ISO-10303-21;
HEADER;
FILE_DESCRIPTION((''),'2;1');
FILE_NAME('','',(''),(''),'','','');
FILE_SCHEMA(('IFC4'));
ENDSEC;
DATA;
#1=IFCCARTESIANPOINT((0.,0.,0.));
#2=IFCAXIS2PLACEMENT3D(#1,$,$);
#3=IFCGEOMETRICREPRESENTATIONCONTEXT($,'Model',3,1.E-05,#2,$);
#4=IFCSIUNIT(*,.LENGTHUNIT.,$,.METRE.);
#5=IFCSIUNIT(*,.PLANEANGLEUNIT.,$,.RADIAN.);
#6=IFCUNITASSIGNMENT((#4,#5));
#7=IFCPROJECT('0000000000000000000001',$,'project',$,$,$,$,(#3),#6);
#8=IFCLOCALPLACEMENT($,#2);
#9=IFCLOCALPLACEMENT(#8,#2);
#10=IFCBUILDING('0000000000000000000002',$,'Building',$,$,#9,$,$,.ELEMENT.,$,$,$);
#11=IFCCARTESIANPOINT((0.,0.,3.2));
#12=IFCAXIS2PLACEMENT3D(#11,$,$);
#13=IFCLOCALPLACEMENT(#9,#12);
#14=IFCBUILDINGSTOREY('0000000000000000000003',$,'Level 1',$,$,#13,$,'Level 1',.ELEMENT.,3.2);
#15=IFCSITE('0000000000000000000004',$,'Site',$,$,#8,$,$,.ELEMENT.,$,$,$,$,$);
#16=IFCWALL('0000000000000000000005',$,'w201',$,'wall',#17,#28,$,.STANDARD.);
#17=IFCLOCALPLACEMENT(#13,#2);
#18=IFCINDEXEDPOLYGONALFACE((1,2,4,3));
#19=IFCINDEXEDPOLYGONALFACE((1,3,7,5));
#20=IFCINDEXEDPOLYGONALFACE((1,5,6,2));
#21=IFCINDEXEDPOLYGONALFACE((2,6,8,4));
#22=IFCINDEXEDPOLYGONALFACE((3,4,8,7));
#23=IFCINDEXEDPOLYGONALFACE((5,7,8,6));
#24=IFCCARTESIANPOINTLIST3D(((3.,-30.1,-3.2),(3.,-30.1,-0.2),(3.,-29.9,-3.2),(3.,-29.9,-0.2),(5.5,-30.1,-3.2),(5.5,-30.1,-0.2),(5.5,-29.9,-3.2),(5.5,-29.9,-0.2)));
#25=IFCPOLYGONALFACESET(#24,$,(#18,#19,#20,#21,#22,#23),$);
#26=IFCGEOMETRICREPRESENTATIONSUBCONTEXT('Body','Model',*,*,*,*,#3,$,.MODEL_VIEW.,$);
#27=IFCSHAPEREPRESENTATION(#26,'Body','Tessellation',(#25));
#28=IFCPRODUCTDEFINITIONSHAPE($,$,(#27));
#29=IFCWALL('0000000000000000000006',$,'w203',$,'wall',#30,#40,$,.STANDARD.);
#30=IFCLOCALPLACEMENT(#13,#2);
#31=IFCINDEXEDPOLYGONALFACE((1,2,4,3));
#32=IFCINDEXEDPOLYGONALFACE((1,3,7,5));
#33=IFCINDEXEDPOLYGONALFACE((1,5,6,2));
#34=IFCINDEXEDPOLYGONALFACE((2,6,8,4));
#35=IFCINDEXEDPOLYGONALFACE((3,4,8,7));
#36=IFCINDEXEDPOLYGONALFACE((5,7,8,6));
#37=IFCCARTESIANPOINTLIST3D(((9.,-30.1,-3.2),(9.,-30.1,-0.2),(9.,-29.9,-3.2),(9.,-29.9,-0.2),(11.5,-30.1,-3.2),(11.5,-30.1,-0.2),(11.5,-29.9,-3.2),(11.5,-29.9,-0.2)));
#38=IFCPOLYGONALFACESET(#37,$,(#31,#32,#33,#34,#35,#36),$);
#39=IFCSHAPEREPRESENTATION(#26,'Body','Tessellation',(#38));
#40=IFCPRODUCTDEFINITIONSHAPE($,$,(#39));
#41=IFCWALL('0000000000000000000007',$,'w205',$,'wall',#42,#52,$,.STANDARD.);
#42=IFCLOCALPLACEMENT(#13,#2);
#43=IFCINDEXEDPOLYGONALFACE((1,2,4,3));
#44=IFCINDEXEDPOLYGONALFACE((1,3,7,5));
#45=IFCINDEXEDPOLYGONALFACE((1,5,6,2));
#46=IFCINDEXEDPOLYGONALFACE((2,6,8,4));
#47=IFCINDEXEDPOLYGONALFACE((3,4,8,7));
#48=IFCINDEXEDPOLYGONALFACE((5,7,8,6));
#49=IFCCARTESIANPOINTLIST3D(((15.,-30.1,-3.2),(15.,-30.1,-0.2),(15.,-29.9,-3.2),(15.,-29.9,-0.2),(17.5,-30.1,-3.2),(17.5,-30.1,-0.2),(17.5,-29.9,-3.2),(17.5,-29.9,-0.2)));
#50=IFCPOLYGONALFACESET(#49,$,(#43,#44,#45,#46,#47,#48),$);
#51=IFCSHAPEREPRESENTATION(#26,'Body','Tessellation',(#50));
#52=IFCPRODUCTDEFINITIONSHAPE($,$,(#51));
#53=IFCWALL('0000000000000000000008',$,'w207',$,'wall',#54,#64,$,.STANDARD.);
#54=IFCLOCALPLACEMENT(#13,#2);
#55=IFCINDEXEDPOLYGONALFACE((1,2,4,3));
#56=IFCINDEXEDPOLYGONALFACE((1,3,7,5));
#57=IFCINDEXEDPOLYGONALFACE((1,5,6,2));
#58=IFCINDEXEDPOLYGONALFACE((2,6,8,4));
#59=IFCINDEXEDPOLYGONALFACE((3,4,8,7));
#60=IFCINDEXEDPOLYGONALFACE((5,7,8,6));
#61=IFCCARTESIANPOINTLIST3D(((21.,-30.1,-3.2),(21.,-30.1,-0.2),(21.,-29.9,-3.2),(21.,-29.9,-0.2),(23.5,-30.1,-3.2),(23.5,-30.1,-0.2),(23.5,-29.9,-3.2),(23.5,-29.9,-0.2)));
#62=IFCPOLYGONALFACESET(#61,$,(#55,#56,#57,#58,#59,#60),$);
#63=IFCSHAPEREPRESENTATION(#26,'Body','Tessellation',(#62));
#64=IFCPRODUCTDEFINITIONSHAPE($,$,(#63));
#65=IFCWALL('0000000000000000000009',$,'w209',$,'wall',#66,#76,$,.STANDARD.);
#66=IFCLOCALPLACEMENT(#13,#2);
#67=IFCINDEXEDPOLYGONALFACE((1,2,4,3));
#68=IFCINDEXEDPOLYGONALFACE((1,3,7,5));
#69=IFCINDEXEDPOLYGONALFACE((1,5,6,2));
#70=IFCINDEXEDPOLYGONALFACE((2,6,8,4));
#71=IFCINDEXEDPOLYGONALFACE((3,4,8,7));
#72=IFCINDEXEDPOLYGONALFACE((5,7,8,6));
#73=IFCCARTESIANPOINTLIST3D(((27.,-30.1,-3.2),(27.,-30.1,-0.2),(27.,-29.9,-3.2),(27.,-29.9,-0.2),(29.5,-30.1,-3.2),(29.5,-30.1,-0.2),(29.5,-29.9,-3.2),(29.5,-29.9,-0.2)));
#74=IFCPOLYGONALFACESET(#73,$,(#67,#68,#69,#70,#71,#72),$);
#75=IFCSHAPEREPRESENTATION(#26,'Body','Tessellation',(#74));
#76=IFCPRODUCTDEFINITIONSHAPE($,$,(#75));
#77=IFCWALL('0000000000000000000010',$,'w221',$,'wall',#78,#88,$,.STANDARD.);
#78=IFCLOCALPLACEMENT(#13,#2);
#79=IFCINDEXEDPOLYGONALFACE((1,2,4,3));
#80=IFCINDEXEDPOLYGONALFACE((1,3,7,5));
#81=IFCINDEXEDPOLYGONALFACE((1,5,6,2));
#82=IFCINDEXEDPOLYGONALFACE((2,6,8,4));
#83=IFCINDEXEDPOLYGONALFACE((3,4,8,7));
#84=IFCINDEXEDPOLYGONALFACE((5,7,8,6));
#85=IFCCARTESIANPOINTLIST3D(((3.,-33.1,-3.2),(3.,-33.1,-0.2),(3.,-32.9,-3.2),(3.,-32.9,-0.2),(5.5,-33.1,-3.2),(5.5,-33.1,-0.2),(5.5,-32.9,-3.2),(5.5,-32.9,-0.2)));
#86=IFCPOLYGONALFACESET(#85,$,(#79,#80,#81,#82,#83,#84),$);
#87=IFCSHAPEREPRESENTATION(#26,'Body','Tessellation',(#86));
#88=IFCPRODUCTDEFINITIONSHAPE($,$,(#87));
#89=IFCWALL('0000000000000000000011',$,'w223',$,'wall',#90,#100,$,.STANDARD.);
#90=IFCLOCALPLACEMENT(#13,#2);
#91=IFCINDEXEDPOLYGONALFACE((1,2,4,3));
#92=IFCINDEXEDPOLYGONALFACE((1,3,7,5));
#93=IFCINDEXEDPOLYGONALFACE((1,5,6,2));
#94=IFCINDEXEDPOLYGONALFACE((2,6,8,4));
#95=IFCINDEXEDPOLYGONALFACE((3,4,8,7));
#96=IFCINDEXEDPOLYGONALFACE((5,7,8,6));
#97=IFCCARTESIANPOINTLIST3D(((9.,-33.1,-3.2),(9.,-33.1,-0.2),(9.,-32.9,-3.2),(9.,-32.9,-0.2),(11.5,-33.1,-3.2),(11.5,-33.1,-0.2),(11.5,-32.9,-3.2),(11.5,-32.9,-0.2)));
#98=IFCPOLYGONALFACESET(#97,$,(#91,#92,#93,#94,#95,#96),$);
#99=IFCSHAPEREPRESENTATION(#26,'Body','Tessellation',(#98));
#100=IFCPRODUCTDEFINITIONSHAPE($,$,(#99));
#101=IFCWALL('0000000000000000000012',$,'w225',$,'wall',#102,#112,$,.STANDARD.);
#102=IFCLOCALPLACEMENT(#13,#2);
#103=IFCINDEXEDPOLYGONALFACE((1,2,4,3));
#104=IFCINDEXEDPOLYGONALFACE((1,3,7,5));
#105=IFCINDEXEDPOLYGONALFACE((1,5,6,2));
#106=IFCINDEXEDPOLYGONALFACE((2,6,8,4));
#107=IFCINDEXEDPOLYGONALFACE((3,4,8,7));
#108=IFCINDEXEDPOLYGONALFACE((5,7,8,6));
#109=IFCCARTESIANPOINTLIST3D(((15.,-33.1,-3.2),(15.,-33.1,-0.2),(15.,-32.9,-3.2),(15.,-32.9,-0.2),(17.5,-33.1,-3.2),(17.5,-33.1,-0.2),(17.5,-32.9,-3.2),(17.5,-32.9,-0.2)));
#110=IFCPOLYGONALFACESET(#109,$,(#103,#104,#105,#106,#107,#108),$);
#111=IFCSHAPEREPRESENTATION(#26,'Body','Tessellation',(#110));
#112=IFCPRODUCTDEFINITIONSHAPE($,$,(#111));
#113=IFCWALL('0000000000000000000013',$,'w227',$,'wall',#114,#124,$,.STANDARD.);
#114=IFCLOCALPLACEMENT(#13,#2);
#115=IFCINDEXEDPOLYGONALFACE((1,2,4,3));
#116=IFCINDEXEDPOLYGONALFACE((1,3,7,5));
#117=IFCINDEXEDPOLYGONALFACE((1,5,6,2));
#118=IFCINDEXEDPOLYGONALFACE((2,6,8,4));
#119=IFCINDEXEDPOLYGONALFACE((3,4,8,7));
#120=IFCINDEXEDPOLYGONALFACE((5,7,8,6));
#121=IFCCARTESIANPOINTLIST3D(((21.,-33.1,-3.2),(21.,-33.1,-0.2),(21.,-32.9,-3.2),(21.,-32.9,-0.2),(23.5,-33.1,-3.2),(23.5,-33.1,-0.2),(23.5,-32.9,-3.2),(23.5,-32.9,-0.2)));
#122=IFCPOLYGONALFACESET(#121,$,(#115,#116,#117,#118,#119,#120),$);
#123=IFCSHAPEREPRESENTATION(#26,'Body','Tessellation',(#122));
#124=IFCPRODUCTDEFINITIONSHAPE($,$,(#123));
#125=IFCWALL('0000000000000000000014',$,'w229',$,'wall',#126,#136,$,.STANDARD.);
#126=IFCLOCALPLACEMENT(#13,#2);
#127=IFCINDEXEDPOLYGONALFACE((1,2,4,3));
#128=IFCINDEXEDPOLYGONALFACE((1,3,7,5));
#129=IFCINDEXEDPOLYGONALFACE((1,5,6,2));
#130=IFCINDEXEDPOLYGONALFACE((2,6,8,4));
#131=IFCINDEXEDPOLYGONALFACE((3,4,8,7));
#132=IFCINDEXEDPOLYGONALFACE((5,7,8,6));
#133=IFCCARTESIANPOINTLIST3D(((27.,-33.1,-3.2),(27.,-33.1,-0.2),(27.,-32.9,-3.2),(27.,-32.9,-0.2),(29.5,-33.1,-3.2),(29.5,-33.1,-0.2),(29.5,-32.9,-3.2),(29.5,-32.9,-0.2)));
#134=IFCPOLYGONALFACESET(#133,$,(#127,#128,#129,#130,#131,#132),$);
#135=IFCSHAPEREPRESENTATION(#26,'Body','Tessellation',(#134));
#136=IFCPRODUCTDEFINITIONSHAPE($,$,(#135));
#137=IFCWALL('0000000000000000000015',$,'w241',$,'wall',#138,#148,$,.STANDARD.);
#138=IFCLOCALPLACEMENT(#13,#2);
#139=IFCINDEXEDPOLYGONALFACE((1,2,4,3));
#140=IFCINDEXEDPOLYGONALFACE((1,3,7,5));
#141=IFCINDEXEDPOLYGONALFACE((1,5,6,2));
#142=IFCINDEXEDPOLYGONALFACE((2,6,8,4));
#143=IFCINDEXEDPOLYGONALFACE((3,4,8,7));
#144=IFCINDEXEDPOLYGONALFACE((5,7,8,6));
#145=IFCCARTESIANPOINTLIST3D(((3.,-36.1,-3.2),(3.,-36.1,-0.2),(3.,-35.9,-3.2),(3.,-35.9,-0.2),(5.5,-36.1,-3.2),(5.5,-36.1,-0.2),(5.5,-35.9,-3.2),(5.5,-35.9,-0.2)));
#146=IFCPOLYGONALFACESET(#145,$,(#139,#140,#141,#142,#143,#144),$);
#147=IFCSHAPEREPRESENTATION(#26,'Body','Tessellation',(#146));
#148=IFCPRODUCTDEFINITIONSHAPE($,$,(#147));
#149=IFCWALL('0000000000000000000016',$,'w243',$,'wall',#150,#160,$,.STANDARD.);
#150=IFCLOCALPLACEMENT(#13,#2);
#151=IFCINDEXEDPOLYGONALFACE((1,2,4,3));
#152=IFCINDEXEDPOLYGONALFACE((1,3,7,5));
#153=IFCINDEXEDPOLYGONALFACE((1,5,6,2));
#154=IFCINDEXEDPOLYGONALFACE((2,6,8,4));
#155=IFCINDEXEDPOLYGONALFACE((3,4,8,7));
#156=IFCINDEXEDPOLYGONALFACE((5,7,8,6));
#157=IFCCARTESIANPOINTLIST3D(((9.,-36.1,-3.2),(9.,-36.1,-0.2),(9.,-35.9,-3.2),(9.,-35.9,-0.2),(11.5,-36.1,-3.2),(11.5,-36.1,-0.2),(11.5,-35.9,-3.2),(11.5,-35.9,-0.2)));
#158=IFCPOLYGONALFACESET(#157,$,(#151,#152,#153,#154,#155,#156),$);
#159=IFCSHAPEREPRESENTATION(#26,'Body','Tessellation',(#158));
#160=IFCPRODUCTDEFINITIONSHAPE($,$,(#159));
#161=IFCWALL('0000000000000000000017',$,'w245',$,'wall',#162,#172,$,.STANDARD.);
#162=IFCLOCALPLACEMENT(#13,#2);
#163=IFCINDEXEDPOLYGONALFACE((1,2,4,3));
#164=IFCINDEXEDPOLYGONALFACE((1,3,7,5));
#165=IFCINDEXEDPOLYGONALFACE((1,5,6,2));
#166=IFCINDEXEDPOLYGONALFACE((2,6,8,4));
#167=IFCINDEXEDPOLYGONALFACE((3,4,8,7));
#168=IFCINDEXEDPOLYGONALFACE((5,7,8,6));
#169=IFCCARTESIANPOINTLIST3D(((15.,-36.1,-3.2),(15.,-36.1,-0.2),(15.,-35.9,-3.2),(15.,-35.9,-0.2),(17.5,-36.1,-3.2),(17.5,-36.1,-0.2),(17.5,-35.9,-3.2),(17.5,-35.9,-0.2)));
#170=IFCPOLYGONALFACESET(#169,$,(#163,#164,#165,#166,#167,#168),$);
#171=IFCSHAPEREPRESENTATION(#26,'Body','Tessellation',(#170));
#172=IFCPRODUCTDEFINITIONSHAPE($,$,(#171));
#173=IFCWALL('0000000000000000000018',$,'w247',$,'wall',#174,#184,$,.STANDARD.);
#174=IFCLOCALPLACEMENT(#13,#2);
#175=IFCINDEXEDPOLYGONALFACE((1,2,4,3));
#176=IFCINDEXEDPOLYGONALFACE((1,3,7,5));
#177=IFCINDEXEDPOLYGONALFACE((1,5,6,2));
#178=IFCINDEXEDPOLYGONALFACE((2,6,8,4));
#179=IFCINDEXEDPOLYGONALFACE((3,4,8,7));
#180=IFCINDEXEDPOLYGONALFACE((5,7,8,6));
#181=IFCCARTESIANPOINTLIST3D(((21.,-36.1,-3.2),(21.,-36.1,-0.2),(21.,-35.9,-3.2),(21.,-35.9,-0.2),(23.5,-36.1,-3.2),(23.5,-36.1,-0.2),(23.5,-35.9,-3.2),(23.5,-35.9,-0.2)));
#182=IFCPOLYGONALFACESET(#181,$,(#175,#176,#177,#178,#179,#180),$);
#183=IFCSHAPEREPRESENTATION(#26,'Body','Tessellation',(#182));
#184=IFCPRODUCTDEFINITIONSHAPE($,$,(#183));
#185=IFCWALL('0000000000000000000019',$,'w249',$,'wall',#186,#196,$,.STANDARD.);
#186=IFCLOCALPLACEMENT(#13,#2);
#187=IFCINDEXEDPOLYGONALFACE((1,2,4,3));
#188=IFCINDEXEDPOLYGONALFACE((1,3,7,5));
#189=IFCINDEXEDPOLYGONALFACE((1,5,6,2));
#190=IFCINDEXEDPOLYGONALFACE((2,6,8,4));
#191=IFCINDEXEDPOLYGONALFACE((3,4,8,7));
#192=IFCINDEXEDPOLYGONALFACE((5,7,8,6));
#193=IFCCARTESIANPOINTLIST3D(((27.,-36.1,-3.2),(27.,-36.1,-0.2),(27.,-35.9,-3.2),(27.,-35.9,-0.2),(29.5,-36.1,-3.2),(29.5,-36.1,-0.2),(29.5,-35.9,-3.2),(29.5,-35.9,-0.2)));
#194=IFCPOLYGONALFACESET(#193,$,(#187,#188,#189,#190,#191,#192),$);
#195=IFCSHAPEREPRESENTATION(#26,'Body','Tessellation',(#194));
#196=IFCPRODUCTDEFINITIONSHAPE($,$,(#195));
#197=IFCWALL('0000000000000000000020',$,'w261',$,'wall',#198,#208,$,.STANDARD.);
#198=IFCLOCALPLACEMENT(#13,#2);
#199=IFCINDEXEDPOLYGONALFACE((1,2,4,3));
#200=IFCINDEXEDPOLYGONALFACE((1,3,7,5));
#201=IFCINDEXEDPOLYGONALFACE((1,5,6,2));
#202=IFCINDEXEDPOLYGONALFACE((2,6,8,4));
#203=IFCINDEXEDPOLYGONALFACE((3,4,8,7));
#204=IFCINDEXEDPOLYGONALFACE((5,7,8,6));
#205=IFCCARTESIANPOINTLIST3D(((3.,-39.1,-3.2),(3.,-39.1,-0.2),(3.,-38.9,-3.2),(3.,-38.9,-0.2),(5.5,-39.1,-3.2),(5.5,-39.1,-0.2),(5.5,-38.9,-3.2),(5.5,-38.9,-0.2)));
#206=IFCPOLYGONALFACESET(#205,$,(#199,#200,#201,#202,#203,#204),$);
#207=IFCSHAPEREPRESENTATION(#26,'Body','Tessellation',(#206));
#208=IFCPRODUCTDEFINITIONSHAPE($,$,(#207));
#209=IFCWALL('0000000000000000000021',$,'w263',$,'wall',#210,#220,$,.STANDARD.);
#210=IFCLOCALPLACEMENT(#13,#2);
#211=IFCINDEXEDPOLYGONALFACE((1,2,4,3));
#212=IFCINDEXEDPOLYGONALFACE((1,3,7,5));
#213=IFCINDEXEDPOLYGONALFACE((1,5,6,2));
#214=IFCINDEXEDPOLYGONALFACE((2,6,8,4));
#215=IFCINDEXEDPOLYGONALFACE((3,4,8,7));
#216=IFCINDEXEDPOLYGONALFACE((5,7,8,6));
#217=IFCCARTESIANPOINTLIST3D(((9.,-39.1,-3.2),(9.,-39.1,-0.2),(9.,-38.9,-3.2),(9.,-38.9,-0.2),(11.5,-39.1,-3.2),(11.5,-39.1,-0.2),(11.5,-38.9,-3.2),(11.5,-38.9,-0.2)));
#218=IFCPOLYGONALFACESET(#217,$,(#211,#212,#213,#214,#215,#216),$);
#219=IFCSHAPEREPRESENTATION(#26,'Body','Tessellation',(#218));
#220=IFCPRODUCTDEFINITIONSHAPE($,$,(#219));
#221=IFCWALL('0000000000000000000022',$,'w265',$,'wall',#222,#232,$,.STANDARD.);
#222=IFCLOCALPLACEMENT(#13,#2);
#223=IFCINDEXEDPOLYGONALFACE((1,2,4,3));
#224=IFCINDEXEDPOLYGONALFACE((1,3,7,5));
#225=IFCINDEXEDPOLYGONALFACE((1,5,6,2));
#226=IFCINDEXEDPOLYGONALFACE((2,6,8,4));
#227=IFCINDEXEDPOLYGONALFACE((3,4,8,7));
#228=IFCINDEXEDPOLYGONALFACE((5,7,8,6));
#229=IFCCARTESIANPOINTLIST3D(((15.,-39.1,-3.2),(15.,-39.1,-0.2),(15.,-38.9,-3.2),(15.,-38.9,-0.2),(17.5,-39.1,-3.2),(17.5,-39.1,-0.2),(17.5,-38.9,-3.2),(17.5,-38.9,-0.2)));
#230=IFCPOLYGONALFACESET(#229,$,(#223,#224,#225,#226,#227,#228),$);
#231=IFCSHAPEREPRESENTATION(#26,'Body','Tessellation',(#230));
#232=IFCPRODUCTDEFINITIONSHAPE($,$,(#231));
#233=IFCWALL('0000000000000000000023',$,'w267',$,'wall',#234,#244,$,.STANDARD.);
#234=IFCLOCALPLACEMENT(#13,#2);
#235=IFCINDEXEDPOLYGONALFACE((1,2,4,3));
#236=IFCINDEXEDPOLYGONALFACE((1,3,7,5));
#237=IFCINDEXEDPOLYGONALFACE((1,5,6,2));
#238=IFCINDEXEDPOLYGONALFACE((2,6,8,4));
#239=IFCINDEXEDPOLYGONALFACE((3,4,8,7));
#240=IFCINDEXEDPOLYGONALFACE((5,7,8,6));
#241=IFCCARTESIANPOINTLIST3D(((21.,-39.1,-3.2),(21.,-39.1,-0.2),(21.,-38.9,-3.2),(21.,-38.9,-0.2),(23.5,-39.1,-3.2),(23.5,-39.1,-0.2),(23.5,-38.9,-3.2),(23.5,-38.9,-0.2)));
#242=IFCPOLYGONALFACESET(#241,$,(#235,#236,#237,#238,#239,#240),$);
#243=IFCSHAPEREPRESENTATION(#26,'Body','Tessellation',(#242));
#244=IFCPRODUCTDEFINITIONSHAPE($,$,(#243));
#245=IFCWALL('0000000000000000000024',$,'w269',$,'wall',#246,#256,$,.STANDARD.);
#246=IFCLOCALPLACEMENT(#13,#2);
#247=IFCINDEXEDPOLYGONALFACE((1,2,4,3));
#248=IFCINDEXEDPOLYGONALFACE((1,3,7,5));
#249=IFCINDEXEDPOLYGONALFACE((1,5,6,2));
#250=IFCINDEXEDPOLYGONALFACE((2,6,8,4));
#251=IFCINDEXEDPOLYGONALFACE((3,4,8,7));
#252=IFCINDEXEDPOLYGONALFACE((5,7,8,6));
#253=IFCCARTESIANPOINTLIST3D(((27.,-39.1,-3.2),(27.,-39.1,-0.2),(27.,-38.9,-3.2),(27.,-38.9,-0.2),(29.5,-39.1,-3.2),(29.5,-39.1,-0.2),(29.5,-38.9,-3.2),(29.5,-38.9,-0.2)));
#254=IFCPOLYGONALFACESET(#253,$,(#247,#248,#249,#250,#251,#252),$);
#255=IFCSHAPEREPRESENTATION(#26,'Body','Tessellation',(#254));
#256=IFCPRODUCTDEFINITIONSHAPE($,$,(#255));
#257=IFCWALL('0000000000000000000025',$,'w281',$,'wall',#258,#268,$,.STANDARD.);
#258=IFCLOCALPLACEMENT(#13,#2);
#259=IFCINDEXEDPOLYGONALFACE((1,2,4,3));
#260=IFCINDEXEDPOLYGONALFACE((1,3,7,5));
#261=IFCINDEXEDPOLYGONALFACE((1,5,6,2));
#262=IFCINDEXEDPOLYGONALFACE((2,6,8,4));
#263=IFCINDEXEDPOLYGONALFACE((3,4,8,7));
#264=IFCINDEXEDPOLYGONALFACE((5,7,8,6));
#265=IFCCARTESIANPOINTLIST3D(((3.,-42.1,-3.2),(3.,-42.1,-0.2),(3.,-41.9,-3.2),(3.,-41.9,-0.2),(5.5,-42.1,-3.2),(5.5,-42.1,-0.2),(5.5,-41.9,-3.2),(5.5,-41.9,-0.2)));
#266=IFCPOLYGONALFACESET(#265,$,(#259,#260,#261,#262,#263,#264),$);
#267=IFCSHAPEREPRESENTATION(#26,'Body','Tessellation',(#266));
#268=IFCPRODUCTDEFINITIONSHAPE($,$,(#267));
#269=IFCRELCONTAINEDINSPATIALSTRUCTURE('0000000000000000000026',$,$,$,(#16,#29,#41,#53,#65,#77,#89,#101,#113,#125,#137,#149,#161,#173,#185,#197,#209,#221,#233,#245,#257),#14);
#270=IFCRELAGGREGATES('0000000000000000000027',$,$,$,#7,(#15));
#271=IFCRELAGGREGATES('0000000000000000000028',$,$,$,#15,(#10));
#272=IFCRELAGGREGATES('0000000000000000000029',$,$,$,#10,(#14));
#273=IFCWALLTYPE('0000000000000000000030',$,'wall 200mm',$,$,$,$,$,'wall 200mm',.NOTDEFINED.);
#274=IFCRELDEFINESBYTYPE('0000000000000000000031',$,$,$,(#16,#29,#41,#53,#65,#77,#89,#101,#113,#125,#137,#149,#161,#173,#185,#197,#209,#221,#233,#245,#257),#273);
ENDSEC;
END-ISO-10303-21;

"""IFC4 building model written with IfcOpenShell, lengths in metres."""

from ifc_helpers import new_model, si_unit, frame, frame_2d, origin, place, context, subcontext, project, spatial, rectangle, extrude, type_object, element, save


model = new_model("IFC4")

# Units and contexts
model_context = context("Model", 3, precision=1e-05, world=origin())
body_context = subcontext(model_context, "Body", "Model", "MODEL_VIEW")
ifc_project = project(units=[si_unit("LENGTHUNIT", "METRE"), si_unit("PLANEANGLEUNIT", "RADIAN")], contexts=[model_context])

# Site, building, storey
site_placement = place(None, origin())
site = spatial("IfcSite", under=ifc_project, at=site_placement, Name="Site", CompositionType="ELEMENT")
building_placement = place(site_placement, origin())
building = spatial("IfcBuilding", under=site, at=building_placement, Name="Building", CompositionType="ELEMENT")
storey_placement = place(building_placement, frame((0.0, 0.0, 3.2)))
storey = spatial("IfcBuildingStorey", under=building, at=storey_placement, Name="Level 1", LongName="Level 1", CompositionType="ELEMENT", Elevation=3.2)

# Walls
wall_type = type_object("IfcWallType", Name="wall 200mm", ElementType="wall 200mm", PredefinedType="NOTDEFINED")
for number, where, z_axis, x_axis, name in (
    (1, (3.0, -30.0, -3.2), (0.0, 0.0, 1.0), (1.0, 0.0, 0.0), "w201"),
    (2, (9.0, -30.0, -3.2), (0.0, 0.0, 1.0), (1.0, 0.0, 0.0), "w203"),
    (3, (15.0, -30.0, -3.2), (0.0, 0.0, 1.0), (1.0, 0.0, 0.0), "w205"),
    (4, (21.0, -30.0, -3.2), (0.0, 0.0, 1.0), (1.0, 0.0, 0.0), "w207"),
    (5, (27.0, -30.0, -3.2), (0.0, 0.0, 1.0), (1.0, 0.0, 0.0), "w209"),
    (6, (3.0, -33.0, -3.2), (0.0, 0.0, 1.0), (1.0, 0.0, 0.0), "w221"),
    (7, (9.0, -33.0, -3.2), (0.0, 0.0, 1.0), (1.0, 0.0, 0.0), "w223"),
    (8, (15.0, -33.0, -3.2), (0.0, 0.0, 1.0), (1.0, 0.0, 0.0), "w225"),
    (9, (21.0, -33.0, -3.2), (0.0, 0.0, 1.0), (1.0, 0.0, 0.0), "w227"),
    (10, (27.0, -33.0, -3.2), (0.0, 0.0, 1.0), (1.0, 0.0, 0.0), "w229"),
    (11, (3.0, -36.0, -3.2), (0.0, 0.0, 1.0), (1.0, 0.0, 0.0), "w241"),
    (12, (9.0, -36.0, -3.2), (0.0, 0.0, 1.0), (1.0, 0.0, 0.0), "w243"),
    (13, (15.0, -36.0, -3.2), (0.0, 0.0, 1.0), (1.0, 0.0, 0.0), "w245"),
    (14, (21.0, -36.0, -3.2), (0.0, 0.0, 1.0), (1.0, 0.0, 0.0), "w247"),
    (15, (27.0, -36.0, -3.2), (0.0, 0.0, 1.0), (1.0, 0.0, 0.0), "w249"),
    (16, (3.0, -39.0, -3.2), (0.0, 0.0, 1.0), (1.0, 0.0, 0.0), "w261"),
    (17, (9.0, -39.0, -3.2), (0.0, 0.0, 1.0), (1.0, 0.0, 0.0), "w263"),
    (18, (15.0, -39.0, -3.2), (0.0, 0.0, 1.0), (1.0, 0.0, 0.0), "w265"),
    (19, (21.0, -39.0, -3.2), (0.0, 0.0, 1.0), (1.0, 0.0, 0.0), "w267"),
    (20, (27.0, -39.0, -3.2), (0.0, 0.0, 1.0), (1.0, 0.0, 0.0), "w269"),
    (21, (3.0, -42.0, -3.2), (0.0, 0.0, 1.0), (1.0, 0.0, 0.0), "w281"),
):
    element("IfcWall", number, at=place(storey_placement, frame(where, z_axis=z_axis, x_axis=x_axis)), inside=storey, type_object=wall_type, Name=name, ObjectType="wall", PredefinedType="STANDARD", context=body_context, shape_type="SweptSolid", body=[
        extrude(rectangle(XDim=2.5, YDim=0.2, at=frame_2d((1.25, 0.0))), origin(), (0.0, 0.0, 1.0), 3.0),
    ])

save(model, "model.ifc")
